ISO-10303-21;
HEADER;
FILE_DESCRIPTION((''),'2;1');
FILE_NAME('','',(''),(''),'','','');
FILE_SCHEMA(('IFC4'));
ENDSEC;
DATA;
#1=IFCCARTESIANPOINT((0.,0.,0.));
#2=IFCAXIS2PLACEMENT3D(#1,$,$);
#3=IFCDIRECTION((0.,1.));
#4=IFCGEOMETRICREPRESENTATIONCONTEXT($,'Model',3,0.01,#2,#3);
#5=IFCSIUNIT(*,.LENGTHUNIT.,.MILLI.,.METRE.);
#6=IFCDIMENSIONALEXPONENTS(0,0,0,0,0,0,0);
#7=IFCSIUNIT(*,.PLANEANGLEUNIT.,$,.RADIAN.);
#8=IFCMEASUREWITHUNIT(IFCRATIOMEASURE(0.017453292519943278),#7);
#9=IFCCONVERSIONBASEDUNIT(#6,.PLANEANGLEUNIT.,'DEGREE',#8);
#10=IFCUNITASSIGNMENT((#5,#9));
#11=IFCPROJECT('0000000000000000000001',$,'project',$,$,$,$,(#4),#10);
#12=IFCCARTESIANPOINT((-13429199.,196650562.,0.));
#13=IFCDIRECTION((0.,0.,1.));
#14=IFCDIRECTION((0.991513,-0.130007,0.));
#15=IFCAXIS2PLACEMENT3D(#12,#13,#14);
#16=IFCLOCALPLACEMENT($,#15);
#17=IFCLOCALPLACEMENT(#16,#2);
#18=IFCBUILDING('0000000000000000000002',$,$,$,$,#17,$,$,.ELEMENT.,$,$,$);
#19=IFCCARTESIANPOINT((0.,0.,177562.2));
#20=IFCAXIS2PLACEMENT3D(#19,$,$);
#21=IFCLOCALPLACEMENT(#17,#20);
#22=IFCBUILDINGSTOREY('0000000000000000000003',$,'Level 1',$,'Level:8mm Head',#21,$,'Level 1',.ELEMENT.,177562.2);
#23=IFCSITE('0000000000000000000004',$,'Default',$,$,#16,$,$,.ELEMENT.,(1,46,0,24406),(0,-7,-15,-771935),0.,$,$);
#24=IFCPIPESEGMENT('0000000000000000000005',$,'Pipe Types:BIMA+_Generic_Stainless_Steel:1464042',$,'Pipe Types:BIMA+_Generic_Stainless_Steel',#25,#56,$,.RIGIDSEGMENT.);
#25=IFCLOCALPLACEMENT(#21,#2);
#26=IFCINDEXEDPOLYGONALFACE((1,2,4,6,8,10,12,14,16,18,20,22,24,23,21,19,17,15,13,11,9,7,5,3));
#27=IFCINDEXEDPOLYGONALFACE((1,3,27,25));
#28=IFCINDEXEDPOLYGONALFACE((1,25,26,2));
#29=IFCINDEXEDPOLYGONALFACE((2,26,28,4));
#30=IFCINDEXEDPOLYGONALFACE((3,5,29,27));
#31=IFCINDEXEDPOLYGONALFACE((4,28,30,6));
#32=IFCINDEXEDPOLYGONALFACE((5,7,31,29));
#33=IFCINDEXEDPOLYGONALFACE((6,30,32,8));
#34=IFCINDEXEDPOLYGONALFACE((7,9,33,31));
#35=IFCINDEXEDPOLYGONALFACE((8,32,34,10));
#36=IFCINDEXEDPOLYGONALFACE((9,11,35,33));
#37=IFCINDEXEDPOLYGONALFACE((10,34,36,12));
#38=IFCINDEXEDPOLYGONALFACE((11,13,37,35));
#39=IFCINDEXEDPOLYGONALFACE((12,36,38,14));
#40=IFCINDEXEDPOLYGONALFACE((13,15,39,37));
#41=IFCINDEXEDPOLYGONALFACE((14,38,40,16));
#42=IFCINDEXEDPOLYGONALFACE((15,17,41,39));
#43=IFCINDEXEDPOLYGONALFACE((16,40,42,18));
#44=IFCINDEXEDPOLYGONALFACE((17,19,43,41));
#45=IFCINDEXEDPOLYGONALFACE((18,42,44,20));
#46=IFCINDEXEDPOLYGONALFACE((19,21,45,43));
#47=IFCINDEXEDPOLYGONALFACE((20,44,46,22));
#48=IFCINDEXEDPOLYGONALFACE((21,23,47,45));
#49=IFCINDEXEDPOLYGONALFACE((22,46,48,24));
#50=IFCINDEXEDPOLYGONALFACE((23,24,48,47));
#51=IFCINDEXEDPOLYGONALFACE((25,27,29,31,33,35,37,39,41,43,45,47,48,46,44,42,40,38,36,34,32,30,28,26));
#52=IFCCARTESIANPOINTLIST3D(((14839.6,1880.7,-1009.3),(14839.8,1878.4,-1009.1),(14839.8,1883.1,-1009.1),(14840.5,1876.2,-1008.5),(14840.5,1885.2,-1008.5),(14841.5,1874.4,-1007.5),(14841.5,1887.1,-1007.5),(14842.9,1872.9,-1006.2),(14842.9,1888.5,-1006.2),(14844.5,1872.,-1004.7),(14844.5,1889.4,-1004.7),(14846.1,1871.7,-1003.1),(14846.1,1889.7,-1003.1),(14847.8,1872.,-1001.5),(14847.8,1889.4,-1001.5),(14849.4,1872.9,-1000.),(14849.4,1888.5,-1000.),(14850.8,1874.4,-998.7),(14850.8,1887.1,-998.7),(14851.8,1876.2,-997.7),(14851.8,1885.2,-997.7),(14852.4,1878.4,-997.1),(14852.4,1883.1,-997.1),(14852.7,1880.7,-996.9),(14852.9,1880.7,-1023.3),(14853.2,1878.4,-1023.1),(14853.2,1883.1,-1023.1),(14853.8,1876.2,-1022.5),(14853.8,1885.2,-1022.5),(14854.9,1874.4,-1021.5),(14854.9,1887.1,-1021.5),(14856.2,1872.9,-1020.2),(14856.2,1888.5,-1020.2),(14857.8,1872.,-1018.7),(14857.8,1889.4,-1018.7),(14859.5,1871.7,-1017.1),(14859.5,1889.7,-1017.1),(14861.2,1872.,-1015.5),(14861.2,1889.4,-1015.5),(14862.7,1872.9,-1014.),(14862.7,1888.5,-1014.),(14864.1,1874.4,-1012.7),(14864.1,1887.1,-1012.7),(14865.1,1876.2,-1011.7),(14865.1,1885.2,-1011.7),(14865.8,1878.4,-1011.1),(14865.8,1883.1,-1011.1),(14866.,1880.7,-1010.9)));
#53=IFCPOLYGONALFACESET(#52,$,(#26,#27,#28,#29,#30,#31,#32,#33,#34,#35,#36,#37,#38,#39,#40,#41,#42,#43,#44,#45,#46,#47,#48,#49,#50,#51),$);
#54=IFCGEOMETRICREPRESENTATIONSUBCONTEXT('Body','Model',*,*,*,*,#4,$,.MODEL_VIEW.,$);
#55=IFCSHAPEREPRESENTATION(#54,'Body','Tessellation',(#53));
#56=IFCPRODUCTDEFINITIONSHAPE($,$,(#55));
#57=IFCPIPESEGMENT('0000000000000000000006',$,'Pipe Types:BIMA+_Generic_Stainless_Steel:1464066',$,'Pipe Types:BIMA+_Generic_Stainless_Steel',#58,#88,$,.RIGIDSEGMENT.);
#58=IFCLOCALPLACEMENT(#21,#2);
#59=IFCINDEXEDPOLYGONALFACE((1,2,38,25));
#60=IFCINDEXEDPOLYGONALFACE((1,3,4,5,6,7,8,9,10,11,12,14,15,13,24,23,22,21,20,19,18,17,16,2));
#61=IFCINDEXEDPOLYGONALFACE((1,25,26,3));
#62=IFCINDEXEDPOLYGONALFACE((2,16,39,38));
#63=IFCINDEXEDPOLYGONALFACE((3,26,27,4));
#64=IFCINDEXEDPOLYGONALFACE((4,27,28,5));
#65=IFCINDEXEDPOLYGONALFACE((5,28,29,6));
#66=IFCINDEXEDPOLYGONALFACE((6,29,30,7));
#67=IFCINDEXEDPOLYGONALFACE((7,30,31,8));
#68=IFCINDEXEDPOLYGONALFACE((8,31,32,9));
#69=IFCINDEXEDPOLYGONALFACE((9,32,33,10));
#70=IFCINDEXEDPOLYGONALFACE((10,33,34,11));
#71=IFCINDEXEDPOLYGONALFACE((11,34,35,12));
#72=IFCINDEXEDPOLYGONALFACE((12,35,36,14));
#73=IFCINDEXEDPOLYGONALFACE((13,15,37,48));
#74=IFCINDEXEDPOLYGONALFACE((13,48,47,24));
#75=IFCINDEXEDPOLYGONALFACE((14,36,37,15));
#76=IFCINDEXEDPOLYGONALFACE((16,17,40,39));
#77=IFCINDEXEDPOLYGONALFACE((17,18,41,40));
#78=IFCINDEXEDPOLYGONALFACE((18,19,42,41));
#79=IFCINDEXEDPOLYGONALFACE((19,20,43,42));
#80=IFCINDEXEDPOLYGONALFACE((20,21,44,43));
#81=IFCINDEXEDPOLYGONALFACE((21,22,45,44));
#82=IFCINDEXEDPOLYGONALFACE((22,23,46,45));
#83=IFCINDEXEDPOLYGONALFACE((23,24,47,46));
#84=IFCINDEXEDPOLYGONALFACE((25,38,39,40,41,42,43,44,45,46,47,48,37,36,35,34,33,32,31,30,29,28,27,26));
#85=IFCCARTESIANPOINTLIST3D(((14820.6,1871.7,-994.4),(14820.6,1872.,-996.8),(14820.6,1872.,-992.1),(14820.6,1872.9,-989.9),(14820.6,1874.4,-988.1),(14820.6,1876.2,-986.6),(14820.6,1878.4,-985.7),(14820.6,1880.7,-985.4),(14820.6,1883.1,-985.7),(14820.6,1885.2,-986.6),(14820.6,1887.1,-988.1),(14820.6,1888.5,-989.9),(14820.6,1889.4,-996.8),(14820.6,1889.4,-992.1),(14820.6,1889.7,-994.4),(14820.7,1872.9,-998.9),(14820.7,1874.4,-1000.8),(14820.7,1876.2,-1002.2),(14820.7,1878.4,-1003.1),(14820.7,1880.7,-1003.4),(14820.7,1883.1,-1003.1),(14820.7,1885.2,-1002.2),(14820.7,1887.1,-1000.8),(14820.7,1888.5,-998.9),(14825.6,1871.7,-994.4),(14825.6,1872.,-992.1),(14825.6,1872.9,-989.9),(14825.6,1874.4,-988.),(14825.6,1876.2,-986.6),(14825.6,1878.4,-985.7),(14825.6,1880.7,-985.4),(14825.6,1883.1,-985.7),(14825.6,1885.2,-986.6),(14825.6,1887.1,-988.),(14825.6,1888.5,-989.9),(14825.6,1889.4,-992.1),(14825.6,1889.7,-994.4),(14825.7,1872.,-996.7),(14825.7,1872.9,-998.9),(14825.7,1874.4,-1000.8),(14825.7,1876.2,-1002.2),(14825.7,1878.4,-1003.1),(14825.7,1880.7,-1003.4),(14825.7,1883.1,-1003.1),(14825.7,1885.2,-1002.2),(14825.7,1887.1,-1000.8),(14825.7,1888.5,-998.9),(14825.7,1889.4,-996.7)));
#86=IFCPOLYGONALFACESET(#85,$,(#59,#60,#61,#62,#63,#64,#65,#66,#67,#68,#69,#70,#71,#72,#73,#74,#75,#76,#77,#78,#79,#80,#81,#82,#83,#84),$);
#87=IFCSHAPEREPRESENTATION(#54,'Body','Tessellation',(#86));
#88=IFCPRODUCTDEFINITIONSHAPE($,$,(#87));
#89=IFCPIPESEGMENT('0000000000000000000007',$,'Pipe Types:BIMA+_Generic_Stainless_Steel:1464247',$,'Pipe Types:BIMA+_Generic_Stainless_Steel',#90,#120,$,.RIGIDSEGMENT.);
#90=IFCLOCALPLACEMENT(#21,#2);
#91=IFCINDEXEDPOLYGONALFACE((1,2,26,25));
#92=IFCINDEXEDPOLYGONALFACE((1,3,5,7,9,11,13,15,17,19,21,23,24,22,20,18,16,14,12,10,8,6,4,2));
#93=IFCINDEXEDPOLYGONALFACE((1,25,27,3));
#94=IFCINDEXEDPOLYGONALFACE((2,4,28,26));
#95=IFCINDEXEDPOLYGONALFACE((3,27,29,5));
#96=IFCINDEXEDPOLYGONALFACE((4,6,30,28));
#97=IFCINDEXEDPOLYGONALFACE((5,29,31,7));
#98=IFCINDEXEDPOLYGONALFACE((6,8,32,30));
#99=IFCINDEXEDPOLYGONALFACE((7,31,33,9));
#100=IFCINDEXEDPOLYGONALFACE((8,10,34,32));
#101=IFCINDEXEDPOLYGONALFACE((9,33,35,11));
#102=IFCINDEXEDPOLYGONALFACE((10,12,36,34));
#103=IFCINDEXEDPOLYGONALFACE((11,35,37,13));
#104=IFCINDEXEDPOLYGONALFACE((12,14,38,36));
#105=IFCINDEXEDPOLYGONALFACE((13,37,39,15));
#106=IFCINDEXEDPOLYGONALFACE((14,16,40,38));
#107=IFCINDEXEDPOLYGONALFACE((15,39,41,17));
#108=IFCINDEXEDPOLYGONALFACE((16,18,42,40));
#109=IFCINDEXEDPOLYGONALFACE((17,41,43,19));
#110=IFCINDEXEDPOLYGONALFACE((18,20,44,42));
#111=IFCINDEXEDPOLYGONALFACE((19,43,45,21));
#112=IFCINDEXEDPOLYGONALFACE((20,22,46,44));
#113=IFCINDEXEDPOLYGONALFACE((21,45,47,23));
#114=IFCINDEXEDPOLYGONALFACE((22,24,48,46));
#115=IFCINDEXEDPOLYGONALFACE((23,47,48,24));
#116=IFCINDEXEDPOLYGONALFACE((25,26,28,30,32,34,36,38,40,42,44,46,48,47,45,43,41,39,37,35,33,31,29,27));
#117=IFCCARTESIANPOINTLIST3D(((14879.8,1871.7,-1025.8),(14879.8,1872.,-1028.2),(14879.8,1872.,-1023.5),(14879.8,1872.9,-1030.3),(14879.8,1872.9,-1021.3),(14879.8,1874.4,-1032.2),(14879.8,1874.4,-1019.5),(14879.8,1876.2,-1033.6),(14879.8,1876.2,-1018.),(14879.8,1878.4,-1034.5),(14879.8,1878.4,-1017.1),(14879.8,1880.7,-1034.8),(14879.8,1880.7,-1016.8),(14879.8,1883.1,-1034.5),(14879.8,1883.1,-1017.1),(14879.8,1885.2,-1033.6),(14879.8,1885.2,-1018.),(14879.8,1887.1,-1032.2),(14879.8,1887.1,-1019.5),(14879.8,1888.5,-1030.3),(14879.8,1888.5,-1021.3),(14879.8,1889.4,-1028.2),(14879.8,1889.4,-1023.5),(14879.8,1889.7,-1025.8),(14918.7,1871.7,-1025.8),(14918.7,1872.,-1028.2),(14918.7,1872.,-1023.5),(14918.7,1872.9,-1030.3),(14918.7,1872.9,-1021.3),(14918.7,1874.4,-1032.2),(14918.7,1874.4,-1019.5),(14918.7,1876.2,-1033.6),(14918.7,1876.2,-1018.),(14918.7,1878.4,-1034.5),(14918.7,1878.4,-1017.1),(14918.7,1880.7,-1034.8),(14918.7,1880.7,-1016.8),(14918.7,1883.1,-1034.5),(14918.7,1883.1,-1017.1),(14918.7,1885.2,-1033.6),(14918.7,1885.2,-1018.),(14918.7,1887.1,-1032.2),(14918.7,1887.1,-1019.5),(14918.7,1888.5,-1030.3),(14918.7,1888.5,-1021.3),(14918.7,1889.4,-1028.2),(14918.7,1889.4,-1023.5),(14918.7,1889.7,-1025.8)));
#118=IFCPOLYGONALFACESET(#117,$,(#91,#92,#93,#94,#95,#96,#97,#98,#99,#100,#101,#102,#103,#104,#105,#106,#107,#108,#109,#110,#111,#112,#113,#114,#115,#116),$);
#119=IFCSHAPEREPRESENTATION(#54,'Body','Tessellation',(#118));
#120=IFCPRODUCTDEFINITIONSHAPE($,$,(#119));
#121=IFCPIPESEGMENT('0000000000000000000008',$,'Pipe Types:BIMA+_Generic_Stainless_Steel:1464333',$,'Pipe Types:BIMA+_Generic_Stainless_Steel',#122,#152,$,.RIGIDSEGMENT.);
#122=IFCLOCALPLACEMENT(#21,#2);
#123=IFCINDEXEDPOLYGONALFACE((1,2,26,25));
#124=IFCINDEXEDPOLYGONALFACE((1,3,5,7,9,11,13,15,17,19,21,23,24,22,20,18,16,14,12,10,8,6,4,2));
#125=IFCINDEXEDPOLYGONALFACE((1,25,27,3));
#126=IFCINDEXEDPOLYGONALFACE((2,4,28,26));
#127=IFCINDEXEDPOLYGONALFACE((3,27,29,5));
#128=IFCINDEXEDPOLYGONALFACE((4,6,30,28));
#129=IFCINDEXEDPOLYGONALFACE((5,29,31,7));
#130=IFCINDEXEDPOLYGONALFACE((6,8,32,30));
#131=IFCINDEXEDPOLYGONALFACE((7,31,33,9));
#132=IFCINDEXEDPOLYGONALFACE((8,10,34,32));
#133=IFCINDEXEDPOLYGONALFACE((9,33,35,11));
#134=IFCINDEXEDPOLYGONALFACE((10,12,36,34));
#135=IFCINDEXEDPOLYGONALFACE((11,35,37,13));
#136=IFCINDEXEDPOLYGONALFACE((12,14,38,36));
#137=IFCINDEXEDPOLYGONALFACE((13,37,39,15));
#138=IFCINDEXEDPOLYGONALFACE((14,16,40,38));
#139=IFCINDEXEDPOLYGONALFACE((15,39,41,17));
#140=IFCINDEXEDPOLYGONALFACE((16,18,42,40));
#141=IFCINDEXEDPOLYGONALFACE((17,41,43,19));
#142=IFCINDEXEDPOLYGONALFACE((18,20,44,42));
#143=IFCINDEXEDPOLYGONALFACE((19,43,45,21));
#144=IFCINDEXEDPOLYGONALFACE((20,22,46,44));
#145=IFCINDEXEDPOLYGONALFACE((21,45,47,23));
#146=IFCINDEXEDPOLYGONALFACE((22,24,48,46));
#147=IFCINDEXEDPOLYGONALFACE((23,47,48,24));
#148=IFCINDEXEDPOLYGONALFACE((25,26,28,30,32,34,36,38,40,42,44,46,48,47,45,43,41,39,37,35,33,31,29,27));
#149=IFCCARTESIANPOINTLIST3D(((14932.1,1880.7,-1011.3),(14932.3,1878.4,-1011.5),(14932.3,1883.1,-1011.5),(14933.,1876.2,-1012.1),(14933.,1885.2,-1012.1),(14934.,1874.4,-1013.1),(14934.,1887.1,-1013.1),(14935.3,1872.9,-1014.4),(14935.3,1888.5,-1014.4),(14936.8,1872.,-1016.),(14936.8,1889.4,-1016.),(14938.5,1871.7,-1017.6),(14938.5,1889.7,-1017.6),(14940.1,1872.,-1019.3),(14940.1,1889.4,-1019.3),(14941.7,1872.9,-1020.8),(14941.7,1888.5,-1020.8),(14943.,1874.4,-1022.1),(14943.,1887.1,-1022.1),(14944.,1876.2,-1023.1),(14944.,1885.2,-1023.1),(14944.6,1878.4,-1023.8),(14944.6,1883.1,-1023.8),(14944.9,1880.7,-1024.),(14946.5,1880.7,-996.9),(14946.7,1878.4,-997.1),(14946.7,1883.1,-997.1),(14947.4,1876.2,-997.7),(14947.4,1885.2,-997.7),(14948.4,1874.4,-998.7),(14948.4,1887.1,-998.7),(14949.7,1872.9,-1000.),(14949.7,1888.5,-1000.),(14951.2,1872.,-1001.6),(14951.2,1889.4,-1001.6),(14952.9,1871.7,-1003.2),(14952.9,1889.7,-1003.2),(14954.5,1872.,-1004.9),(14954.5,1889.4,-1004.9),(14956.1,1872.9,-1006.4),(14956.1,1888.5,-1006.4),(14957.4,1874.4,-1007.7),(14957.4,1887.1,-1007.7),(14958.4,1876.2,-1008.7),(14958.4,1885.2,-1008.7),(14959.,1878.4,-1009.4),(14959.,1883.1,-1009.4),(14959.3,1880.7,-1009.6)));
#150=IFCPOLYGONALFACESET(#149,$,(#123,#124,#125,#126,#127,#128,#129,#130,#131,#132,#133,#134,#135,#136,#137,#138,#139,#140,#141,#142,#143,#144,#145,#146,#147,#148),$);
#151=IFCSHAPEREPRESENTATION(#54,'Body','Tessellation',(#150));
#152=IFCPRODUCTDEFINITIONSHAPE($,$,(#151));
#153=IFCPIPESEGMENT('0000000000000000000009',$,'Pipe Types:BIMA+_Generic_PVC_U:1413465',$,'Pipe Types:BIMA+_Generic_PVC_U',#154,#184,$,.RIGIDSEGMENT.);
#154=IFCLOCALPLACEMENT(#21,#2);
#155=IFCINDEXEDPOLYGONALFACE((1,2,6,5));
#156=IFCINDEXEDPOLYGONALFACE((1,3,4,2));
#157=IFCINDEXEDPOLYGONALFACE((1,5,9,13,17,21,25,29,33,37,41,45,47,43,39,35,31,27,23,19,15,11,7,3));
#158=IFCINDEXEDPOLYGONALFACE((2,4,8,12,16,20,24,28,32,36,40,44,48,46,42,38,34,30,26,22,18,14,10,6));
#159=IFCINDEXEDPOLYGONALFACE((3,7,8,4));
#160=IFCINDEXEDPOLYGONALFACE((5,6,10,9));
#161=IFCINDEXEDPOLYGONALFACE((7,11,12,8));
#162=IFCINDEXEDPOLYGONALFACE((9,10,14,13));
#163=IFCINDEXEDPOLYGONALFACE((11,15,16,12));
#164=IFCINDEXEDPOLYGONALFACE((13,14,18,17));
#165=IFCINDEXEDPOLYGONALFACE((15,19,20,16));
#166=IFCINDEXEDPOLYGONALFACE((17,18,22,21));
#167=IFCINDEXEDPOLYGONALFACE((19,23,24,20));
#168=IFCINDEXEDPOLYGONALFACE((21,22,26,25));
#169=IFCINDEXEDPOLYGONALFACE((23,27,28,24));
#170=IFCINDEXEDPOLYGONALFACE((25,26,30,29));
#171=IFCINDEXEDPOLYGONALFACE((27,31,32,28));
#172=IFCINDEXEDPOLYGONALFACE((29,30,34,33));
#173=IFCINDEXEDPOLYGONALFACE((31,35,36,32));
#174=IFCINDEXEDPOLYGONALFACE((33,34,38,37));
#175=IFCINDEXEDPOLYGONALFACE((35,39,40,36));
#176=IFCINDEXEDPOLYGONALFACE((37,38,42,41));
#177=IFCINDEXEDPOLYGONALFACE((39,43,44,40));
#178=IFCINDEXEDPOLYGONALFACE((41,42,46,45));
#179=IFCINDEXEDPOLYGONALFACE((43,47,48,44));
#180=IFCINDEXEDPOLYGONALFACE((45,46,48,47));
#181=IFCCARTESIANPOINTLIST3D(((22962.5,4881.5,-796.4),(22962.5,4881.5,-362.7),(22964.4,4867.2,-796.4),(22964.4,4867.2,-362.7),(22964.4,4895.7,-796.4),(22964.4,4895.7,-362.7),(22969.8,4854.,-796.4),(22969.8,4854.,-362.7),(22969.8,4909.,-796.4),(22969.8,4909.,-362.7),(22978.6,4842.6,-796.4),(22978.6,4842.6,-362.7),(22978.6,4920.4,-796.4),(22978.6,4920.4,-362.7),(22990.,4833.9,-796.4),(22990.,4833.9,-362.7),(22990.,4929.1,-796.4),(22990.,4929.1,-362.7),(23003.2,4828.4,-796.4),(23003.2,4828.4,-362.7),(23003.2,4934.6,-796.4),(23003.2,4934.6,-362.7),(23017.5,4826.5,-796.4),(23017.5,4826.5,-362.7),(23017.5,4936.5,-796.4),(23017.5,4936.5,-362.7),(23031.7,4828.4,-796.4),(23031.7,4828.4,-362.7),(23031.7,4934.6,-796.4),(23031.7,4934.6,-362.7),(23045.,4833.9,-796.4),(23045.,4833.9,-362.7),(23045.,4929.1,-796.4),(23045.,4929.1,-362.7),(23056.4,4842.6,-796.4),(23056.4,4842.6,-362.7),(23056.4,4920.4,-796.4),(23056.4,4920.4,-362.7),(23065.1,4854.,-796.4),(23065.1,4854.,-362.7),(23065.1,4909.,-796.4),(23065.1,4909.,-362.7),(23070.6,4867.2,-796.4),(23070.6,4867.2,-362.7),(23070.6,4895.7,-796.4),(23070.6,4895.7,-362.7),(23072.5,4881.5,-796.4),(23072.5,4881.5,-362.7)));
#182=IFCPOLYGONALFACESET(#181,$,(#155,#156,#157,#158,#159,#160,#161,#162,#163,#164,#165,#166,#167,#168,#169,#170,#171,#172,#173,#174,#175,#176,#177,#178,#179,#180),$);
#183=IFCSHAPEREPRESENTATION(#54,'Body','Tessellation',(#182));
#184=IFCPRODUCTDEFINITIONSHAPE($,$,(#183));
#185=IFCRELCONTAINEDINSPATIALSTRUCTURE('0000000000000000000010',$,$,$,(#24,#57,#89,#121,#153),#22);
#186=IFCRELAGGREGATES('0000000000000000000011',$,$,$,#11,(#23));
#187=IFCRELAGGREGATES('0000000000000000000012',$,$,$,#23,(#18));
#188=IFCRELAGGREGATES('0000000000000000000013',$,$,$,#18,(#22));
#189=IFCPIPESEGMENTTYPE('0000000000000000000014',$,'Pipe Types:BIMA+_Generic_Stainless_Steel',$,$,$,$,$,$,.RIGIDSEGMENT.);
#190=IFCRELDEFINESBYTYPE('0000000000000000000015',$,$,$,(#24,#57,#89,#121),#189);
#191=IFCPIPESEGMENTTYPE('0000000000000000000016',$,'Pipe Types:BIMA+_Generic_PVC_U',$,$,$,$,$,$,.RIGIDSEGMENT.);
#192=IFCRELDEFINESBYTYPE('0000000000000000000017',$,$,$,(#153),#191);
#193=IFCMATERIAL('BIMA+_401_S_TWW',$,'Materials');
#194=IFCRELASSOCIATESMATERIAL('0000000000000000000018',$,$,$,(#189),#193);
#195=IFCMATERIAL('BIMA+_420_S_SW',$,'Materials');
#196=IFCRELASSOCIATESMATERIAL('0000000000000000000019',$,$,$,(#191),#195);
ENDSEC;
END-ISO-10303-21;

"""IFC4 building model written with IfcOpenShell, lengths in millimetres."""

from ifc_helpers import new_model, entity, si_unit, converted_unit, direction, frame, origin, place, context, subcontext, project, spatial, arc, indexed_curve, outline, extrude, material, type_object, element, save


model = new_model("IFC4")

# Units and contexts
model_context = context("Model", 3, precision=0.01, world=origin(), true_north=direction((0.0, 1.0)))
body_context = subcontext(model_context, "Body", "Model", "MODEL_VIEW")
ifc_project = project(units=[si_unit("LENGTHUNIT", "METRE", prefix="MILLI"), converted_unit("PLANEANGLEUNIT", "DEGREE", entity("IfcRatioMeasure", 0.017453292519943278), si_unit("PLANEANGLEUNIT", "RADIAN"), dimensions=[0, 0, 0, 0, 0, 0, 0])], contexts=[model_context])

# Site, building, storey
site_placement = place(None, frame((-13429199.0, 196650562.0, 0.0), z_axis=(0.0, 0.0, 1.0), x_axis=(0.991513, -0.130007, 0.0)))
site = spatial("IfcSite", under=ifc_project, at=site_placement, Name="Default", CompositionType="ELEMENT", RefLatitude=(1, 46, 0, 24406), RefLongitude=(0, -7, -15, -771935), RefElevation=0.0)
building_placement = place(site_placement, origin())
building = spatial("IfcBuilding", under=site, at=building_placement, CompositionType="ELEMENT")
storey_placement = place(building_placement, frame((0.0, 0.0, 177562.2)))
storey = spatial("IfcBuildingStorey", under=building, at=storey_placement, Name="Level 1", ObjectType="Level:8mm Head", LongName="Level 1", CompositionType="ELEMENT", Elevation=177562.2)

# Pipe segments
ifc_material_1 = material(Name="BIMA+_401_S_TWW", Category="Materials")
pipe_segment_type_1 = type_object("IfcPipeSegmentType", Name="Pipe Types:BIMA+_Generic_Stainless_Steel", PredefinedType="RIGIDSEGMENT", material=ifc_material_1)
pipe_segment_1_placement = place(storey_placement, frame((14838.0, 1870.1, -995.3)))
element("IfcPipeSegment", 1, at=pipe_segment_1_placement, inside=storey, type_object=pipe_segment_type_1, Name="Pipe Types:BIMA+_Generic_Stainless_Steel:1464042", ObjectType="Pipe Types:BIMA+_Generic_Stainless_Steel", PredefinedType="RIGIDSEGMENT", context=body_context, shape_type="SweptSolid", body=[
    extrude(outline(indexed_curve([(9.0, 0.0), (6.4, 6.4), (0.0, 9.0), (-6.4, 6.4), (-9.0, 0.0), (-6.4, -6.4), (0.0, -9.0), (6.4, -6.4)], segments=[arc(1, 2, 3), arc(3, 4, 5), arc(5, 6, 7), arc(7, 8, 1)], self_intersect=False)), frame((8.1, 10.6, -7.8), z_axis=(0.689068, 0.0, -0.724697), x_axis=(0.0, -1.0, 0.0)), (0.0, 0.0, 1.0), 19.3),
])
pipe_segment_2_placement = place(storey_placement, frame((14820.6, 1870.1, -1005.0)))
element("IfcPipeSegment", 2, at=pipe_segment_2_placement, inside=storey, type_object=pipe_segment_type_1, Name="Pipe Types:BIMA+_Generic_Stainless_Steel:1464066", ObjectType="Pipe Types:BIMA+_Generic_Stainless_Steel", PredefinedType="RIGIDSEGMENT", context=body_context, shape_type="SweptSolid", body=[
    extrude(outline(indexed_curve([(9.0, 0.0), (6.4, 6.4), (0.0, 9.0), (-6.4, 6.4), (-9.0, 0.0), (-6.4, -6.4), (0.0, -9.0), (6.4, -6.4)], segments=[arc(1, 2, 3), arc(3, 4, 5), arc(5, 6, 7), arc(7, 8, 1)], self_intersect=False)), frame((0.1, 10.6, 10.6), z_axis=(0.999973, 0.0, 0.007397), x_axis=(0.0, -1.0, 0.0)), (0.0, 0.0, 1.0), 5.0),
])
pipe_segment_3_placement = place(storey_placement, frame((14879.8, 1870.1, -1036.4)))
element("IfcPipeSegment", 3, at=pipe_segment_3_placement, inside=storey, type_object=pipe_segment_type_1, Name="Pipe Types:BIMA+_Generic_Stainless_Steel:1464247", ObjectType="Pipe Types:BIMA+_Generic_Stainless_Steel", PredefinedType="RIGIDSEGMENT", context=body_context, shape_type="SweptSolid", body=[
    extrude(outline(indexed_curve([(9.0, 0.0), (6.4, 6.4), (0.0, 9.0), (-6.4, 6.4), (-9.0, 0.0), (-6.4, -6.4), (0.0, -9.0), (6.4, -6.4)], segments=[arc(1, 2, 3), arc(3, 4, 5), arc(5, 6, 7), arc(7, 8, 1)], self_intersect=False)), frame((0.0, 10.6, 10.6), z_axis=(1.0, 0.0, 0.0), x_axis=(0.0, -1.0, 0.0)), (0.0, 0.0, 1.0), 38.9),
])
pipe_segment_4_placement = place(storey_placement, frame((14930.5, 1870.1, -1025.6)))
element("IfcPipeSegment", 4, at=pipe_segment_4_placement, inside=storey, type_object=pipe_segment_type_1, Name="Pipe Types:BIMA+_Generic_Stainless_Steel:1464333", ObjectType="Pipe Types:BIMA+_Generic_Stainless_Steel", PredefinedType="RIGIDSEGMENT", context=body_context, shape_type="SweptSolid", body=[
    extrude(outline(indexed_curve([(9.0, 0.0), (6.4, 6.4), (0.0, 9.0), (-6.4, 6.4), (-9.0, 0.0), (-6.4, -6.4), (0.0, -9.0), (6.4, -6.4)], segments=[arc(1, 2, 3), arc(3, 4, 5), arc(5, 6, 7), arc(7, 8, 1)], self_intersect=False)), frame((8.0, 10.6, 8.0), z_axis=(0.707107, 0.0, 0.707107), x_axis=(0.0, -1.0, 0.0)), (0.0, 0.0, 1.0), 20.4),
])
ifc_material_2 = material(Name="BIMA+_420_S_SW", Category="Materials")
pipe_segment_type_2 = type_object("IfcPipeSegmentType", Name="Pipe Types:BIMA+_Generic_PVC_U", PredefinedType="RIGIDSEGMENT", material=ifc_material_2)
pipe_segment_5_placement = place(storey_placement, frame((22960.9, 4824.9, -796.4)))
element("IfcPipeSegment", 5, at=pipe_segment_5_placement, inside=storey, type_object=pipe_segment_type_2, Name="Pipe Types:BIMA+_Generic_PVC_U:1413465", ObjectType="Pipe Types:BIMA+_Generic_PVC_U", PredefinedType="RIGIDSEGMENT", context=body_context, shape_type="SweptSolid", body=[
    extrude(outline(indexed_curve([(55.0, 0.0), (38.9, 38.9), (0.0, 55.0), (-38.9, 38.9), (-55.0, 0.0), (-38.9, -38.9), (0.0, -55.0), (38.9, -38.9)], segments=[arc(1, 2, 3), arc(3, 4, 5), arc(5, 6, 7), arc(7, 8, 1)], self_intersect=False)), frame((56.6, 56.6, 0.0)), (0.0, 0.0, 1.0), 433.7),
])

save(model, "model.ifc")
